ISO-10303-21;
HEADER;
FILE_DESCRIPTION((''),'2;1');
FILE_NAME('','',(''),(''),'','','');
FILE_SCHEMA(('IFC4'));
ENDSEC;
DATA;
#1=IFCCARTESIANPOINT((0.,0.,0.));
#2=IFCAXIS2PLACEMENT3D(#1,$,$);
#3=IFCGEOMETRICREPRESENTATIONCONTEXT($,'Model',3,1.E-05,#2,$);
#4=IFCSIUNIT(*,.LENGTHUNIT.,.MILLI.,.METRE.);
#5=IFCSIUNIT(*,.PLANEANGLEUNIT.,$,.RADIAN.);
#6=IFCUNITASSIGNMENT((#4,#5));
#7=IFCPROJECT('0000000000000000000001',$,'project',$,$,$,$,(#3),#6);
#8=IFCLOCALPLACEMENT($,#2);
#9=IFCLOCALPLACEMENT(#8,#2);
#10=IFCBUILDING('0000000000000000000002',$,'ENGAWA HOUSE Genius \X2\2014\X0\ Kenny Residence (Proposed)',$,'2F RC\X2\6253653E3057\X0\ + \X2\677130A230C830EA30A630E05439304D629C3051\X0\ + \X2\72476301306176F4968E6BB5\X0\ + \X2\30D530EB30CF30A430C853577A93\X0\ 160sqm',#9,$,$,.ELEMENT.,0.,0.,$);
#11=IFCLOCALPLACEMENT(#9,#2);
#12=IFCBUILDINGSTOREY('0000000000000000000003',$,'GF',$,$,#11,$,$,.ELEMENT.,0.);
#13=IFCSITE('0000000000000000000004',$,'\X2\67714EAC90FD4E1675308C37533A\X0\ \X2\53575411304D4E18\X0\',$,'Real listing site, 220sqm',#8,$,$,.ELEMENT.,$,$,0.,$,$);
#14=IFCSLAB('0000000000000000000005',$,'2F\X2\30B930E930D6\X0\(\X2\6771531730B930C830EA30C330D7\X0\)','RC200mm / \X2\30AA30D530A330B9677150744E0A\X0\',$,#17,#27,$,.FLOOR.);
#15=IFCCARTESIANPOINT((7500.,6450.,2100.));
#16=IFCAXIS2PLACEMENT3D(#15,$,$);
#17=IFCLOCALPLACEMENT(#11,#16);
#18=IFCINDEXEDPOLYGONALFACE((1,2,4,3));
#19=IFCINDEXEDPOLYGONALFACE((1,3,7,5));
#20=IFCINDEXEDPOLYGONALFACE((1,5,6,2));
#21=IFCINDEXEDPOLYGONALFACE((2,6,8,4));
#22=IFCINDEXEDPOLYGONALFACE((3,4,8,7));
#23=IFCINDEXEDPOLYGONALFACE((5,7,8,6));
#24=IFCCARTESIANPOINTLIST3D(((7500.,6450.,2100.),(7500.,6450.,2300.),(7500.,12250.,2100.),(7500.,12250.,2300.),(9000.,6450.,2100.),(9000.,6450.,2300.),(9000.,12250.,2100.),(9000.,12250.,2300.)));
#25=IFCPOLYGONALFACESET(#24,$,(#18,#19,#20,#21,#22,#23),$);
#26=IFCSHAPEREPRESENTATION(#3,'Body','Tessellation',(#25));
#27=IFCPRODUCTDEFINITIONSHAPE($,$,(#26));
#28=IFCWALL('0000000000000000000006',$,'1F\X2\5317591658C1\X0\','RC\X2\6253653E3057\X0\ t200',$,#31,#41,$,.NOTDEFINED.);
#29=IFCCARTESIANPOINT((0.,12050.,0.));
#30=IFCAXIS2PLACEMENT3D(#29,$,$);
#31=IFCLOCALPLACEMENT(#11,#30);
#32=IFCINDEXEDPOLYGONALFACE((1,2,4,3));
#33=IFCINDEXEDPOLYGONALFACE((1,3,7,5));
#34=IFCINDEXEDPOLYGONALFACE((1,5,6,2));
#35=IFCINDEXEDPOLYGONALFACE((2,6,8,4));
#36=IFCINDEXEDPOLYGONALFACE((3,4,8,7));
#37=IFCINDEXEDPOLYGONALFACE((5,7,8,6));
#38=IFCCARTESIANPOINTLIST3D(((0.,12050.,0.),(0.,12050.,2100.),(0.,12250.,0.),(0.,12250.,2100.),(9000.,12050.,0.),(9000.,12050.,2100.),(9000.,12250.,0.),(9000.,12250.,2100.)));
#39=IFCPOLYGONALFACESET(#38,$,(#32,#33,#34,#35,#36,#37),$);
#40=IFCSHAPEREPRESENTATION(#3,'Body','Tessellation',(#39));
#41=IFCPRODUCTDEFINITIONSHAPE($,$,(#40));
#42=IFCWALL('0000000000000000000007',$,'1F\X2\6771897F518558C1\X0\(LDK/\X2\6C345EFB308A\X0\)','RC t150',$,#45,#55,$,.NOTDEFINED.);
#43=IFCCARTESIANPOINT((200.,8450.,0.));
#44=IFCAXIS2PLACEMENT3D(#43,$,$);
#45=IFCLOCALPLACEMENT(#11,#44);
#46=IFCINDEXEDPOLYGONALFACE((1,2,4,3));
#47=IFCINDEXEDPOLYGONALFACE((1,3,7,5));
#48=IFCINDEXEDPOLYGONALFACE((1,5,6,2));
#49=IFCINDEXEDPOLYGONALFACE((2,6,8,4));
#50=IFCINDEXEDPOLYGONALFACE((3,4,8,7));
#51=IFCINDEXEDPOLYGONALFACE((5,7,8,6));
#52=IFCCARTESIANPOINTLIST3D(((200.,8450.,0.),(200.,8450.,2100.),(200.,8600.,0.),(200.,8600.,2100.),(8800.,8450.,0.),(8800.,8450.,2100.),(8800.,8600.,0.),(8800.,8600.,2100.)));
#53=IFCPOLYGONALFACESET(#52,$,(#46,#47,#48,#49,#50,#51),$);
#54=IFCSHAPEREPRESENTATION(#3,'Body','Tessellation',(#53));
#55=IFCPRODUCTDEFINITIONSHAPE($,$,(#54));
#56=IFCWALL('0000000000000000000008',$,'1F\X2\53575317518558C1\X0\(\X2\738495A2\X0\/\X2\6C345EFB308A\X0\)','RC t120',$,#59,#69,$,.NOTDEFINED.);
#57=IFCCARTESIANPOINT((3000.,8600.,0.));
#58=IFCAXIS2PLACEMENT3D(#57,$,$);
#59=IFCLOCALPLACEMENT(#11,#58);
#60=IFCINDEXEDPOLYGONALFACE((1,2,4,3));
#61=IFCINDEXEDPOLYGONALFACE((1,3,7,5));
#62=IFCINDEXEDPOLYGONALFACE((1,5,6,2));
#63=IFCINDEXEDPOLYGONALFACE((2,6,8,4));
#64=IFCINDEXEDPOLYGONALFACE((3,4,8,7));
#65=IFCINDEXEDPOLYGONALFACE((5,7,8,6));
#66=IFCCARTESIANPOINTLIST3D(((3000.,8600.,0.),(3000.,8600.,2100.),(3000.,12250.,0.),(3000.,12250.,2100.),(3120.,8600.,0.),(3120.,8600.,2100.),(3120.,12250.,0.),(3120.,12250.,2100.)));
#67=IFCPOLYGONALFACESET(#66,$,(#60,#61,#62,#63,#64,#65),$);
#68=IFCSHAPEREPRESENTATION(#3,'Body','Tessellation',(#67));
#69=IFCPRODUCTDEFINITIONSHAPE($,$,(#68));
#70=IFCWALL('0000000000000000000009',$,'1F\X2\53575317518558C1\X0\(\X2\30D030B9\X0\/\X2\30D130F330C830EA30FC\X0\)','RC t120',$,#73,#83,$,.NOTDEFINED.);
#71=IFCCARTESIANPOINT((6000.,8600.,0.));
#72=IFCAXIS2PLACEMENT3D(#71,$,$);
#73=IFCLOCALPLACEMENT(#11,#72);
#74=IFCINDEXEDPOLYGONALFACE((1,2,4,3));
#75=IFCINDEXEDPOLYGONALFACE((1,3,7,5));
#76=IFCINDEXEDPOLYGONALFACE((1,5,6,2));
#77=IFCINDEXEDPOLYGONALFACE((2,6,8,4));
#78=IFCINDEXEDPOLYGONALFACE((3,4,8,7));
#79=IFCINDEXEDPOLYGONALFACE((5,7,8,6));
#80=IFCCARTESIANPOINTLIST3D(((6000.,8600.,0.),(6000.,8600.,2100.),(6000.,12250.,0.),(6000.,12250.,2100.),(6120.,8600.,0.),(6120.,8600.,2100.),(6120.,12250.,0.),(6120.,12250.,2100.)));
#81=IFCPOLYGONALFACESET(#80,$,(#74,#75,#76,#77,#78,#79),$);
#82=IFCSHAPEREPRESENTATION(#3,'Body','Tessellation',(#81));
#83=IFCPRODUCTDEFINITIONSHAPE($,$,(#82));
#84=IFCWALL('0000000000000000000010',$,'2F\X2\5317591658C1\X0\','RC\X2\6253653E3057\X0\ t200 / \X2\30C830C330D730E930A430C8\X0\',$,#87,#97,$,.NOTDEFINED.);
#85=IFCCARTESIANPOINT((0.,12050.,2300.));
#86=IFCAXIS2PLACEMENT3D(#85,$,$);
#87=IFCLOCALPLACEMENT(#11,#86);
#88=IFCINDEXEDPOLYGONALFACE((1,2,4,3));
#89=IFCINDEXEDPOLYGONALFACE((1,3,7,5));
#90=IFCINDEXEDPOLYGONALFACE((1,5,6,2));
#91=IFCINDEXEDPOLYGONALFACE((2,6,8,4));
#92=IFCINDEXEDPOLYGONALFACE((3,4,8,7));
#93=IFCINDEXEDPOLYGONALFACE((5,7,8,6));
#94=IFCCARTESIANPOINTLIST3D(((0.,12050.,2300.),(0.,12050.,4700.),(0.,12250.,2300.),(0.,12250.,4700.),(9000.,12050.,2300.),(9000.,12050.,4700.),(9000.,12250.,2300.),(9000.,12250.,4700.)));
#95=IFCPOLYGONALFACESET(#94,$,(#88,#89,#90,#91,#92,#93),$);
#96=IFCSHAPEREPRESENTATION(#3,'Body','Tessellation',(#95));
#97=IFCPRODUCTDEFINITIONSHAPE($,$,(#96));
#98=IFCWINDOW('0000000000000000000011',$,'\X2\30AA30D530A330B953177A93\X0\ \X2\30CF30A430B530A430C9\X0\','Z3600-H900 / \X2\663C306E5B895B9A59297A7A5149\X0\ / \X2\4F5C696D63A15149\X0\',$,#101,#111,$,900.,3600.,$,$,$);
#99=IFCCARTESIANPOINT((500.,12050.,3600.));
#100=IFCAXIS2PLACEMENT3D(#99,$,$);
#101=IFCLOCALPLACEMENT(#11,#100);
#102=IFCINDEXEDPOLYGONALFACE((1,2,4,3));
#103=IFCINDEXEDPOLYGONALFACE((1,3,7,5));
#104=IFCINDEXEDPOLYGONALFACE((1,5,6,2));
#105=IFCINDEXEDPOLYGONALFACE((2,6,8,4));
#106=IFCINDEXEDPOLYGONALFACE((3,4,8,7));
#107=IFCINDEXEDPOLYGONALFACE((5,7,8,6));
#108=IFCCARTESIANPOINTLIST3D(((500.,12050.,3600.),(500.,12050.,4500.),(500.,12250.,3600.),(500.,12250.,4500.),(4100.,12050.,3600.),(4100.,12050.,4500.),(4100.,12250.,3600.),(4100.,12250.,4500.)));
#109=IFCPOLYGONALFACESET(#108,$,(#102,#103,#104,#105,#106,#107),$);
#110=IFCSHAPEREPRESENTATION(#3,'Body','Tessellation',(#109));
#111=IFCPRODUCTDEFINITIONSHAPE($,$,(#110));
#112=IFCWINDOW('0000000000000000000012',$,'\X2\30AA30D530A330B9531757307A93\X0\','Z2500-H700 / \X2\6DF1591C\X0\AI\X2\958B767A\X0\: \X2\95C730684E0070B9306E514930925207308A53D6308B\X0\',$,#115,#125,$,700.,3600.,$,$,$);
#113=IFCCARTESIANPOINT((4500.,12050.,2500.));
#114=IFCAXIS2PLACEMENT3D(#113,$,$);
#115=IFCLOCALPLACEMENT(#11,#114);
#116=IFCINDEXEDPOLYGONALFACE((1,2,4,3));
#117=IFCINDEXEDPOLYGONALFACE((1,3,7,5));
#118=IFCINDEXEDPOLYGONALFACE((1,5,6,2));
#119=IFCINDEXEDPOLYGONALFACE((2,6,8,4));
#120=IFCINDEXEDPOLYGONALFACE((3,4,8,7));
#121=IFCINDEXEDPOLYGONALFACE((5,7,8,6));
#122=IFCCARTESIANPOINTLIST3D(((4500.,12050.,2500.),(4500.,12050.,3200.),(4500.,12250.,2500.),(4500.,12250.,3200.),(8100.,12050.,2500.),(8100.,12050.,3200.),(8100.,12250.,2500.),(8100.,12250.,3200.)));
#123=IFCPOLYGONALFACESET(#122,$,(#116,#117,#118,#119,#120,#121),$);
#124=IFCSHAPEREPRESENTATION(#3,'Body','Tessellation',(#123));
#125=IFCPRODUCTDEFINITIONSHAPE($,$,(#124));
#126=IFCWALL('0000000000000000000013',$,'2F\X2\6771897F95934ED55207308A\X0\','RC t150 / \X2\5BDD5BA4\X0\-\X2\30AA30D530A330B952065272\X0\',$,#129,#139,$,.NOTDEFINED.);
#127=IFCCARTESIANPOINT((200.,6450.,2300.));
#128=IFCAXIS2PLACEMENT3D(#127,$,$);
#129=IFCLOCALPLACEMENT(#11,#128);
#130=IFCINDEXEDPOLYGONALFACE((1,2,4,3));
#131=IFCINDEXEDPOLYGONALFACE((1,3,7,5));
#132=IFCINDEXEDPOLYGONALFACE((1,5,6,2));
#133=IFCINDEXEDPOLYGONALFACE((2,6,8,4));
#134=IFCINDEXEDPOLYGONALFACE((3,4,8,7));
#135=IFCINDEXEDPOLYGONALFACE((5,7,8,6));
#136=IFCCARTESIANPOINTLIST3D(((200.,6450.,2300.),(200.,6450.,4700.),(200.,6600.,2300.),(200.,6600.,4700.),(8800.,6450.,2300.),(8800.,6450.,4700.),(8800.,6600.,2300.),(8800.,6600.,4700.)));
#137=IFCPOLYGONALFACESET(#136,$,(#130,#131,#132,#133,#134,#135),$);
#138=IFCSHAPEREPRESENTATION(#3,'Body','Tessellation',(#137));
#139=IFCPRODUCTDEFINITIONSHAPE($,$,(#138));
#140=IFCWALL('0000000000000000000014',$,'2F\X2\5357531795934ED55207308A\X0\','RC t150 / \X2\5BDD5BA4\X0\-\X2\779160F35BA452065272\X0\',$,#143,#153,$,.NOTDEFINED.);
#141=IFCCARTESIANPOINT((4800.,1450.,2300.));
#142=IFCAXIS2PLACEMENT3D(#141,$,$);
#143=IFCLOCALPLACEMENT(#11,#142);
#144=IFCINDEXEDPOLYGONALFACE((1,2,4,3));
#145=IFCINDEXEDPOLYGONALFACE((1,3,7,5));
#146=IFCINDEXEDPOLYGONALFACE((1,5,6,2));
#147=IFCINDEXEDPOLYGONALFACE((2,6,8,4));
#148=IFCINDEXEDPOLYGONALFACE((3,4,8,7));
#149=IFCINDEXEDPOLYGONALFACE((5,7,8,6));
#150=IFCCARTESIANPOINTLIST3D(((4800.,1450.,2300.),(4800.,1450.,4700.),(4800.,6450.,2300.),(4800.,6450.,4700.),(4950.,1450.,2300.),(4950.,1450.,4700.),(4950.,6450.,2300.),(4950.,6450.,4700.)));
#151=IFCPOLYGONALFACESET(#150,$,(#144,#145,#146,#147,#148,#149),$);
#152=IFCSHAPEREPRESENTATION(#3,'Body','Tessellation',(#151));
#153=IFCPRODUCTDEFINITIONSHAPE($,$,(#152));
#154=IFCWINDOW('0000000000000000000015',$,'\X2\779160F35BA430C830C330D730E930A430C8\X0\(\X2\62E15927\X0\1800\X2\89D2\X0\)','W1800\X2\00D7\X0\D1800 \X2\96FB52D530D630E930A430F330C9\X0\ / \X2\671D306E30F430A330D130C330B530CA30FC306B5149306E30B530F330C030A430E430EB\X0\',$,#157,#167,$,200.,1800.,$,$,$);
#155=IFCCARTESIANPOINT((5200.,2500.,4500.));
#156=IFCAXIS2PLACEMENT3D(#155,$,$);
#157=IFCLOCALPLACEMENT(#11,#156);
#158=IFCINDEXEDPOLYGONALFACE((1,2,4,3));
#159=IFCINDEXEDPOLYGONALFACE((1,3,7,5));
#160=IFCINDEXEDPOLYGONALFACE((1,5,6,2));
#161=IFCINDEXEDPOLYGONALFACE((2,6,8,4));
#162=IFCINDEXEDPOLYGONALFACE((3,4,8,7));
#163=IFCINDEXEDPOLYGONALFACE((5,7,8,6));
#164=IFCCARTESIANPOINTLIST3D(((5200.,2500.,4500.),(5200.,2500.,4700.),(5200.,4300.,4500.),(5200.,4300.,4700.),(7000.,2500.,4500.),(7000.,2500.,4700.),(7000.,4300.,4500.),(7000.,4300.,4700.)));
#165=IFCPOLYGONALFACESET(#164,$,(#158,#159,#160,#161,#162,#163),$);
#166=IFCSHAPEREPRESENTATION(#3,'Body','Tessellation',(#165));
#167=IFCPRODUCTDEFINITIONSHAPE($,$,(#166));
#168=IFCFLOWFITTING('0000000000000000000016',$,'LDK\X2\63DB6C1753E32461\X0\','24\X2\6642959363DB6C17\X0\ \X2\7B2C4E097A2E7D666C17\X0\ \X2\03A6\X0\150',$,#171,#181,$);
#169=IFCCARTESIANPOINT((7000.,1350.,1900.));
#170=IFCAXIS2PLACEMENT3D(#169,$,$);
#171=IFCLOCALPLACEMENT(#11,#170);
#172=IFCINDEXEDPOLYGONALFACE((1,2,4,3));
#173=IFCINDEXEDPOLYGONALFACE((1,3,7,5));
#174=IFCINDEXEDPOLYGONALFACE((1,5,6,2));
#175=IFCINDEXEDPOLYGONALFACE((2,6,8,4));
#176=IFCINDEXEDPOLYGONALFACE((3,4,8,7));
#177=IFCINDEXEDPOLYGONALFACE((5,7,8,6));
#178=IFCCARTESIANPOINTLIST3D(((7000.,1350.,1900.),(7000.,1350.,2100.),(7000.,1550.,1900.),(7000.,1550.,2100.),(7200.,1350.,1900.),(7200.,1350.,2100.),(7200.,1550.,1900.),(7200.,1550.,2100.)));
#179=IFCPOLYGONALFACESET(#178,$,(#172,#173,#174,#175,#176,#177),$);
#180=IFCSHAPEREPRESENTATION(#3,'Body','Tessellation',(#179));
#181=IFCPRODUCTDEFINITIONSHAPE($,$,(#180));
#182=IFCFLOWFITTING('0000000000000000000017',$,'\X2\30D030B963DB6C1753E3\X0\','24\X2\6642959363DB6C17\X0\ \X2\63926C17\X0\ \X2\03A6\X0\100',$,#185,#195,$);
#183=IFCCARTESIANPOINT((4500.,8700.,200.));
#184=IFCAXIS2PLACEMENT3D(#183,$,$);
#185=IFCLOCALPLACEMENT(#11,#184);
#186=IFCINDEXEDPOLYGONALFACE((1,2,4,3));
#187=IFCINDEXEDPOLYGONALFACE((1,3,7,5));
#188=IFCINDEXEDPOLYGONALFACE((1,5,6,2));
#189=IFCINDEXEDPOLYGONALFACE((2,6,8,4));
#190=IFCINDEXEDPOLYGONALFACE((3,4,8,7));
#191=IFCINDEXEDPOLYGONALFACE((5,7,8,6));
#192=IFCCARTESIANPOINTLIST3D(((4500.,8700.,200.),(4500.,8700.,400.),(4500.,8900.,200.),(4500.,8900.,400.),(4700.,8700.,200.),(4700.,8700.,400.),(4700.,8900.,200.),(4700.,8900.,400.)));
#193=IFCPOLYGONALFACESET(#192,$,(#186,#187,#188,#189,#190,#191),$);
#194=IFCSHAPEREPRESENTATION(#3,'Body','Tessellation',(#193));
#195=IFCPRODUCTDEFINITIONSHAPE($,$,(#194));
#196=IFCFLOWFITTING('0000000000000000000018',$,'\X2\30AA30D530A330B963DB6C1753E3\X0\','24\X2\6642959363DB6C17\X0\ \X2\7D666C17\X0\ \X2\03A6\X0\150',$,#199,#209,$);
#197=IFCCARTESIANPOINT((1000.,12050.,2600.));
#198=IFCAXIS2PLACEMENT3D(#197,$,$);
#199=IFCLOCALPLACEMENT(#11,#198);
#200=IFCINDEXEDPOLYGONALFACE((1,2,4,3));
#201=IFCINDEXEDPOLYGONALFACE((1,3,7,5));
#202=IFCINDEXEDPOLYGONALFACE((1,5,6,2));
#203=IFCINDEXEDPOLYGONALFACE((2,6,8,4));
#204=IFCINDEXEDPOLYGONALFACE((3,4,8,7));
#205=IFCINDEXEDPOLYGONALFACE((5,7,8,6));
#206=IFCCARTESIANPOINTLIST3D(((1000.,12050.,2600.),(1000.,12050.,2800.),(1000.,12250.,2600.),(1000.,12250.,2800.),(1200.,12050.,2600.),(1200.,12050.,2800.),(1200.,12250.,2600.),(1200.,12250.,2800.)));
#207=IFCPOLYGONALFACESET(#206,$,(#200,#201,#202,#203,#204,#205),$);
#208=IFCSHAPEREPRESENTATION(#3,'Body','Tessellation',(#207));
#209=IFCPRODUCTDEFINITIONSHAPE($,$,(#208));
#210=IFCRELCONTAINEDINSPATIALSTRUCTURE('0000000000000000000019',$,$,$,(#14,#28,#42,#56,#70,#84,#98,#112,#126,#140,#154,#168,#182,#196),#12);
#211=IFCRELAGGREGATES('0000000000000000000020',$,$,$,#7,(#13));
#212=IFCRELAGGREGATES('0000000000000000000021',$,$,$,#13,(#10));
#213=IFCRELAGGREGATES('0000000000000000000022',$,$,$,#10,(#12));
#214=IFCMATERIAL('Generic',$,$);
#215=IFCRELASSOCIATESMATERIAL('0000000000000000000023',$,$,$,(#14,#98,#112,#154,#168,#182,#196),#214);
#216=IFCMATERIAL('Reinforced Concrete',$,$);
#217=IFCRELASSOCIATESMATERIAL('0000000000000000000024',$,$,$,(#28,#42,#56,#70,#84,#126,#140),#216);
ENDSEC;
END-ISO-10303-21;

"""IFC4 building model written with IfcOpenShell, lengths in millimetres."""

from ifc_helpers import new_model, si_unit, frame, frame_2d, origin, place, context, project, spatial, rectangle, extrude, material, element, fill, save


model = new_model("IFC4")

# Units and contexts
model_context = context("Model", 3, precision=1e-05, world=origin())
ifc_project = project(units=[si_unit("LENGTHUNIT", "METRE", prefix="MILLI"), si_unit("PLANEANGLEUNIT", "RADIAN")], contexts=[model_context])

# Site, building, storey
site_placement = place(None, origin())
site = spatial("IfcSite", under=ifc_project, at=site_placement, Name="東京都世田谷区 南向き丘", ObjectType="Real listing site, 220sqm", CompositionType="ELEMENT", RefElevation=0.0)
building_placement = place(site_placement, origin())
building = spatial("IfcBuilding", under=site, at=building_placement, Name="ENGAWA HOUSE Genius — Kenny Residence (Proposed)", ObjectType="2F RC打放し + 東アトリウム吹き抜け + 片持ち直階段 + フルハイト南窓 160sqm", CompositionType="ELEMENT", ElevationOfRefHeight=0.0, ElevationOfTerrain=0.0)
storey_placement = place(building_placement, origin())
storey = spatial("IfcBuildingStorey", under=building, at=storey_placement, Name="GF", CompositionType="ELEMENT", Elevation=0.0)

# Slab
ifc_material_1 = material(Name="Generic")
slab_placement = place(storey_placement, frame((7500.0, 6450.0, 2100.0)))
element("IfcSlab", 1, at=slab_placement, inside=storey, material=ifc_material_1, Name="2Fスラブ(東北ストリップ)", Description="RC200mm / オフィス東側上", PredefinedType="FLOOR", context=model_context, shape_type="SweptSolid", body=[
    extrude(rectangle(XDim=1500.0, YDim=5800.0, at=frame_2d((750.0, 2900.0))), frame((7500.0, 6450.0, 2100.0)), (0.0, 0.0, 1.0), 200.0),
])

# Walls
ifc_material_2 = material(Name="Reinforced Concrete")
wall_1_placement = place(storey_placement, frame((0.0, 12050.0, 0.0)))
element("IfcWall", 2, at=wall_1_placement, inside=storey, material=ifc_material_2, Name="1F北外壁", Description="RC打放し t200", PredefinedType="NOTDEFINED", context=model_context, shape_type="SweptSolid", body=[
    extrude(rectangle(XDim=9000.0, YDim=200.0, at=frame_2d((4500.0, 100.0))), frame((0.0, 12050.0, 0.0)), (0.0, 0.0, 1.0), 2100.0),
])
wall_2_placement = place(storey_placement, frame((200.0, 8450.0, 0.0)))
element("IfcWall", 3, at=wall_2_placement, inside=storey, material=ifc_material_2, Name="1F東西内壁(LDK/水廻り)", Description="RC t150", PredefinedType="NOTDEFINED", context=model_context, shape_type="SweptSolid", body=[
    extrude(rectangle(XDim=8600.0, YDim=150.0, at=frame_2d((4300.0, 75.0))), frame((200.0, 8450.0, 0.0)), (0.0, 0.0, 1.0), 2100.0),
])
wall_3_placement = place(storey_placement, frame((3000.0, 8600.0, 0.0)))
element("IfcWall", 4, at=wall_3_placement, inside=storey, material=ifc_material_2, Name="1F南北内壁(玄関/水廻り)", Description="RC t120", PredefinedType="NOTDEFINED", context=model_context, shape_type="SweptSolid", body=[
    extrude(rectangle(XDim=120.0, YDim=3650.0, at=frame_2d((60.0, 1825.0))), frame((3000.0, 8600.0, 0.0)), (0.0, 0.0, 1.0), 2100.0),
])
wall_4_placement = place(storey_placement, frame((6000.0, 8600.0, 0.0)))
element("IfcWall", 5, at=wall_4_placement, inside=storey, material=ifc_material_2, Name="1F南北内壁(バス/パントリー)", Description="RC t120", PredefinedType="NOTDEFINED", context=model_context, shape_type="SweptSolid", body=[
    extrude(rectangle(XDim=120.0, YDim=3650.0, at=frame_2d((60.0, 1825.0))), frame((6000.0, 8600.0, 0.0)), (0.0, 0.0, 1.0), 2100.0),
])

# Wall, openings, windows
wall_5_placement = place(storey_placement, frame((0.0, 12050.0, 2300.0)))
wall_5 = element("IfcWall", 6, at=wall_5_placement, inside=storey, material=ifc_material_2, Name="2F北外壁", Description="RC打放し t200 / トップライト", PredefinedType="NOTDEFINED", context=model_context, shape_type="SweptSolid", body=[
    extrude(rectangle(XDim=9000.0, YDim=200.0, at=frame_2d((4500.0, 100.0))), frame((0.0, 12050.0, 2300.0)), (0.0, 0.0, 1.0), 2400.0),
])
opening_1_placement = place(storey_placement, frame((500.0, 12050.0, 3600.0)))
opening_1 = element("IfcOpeningElement", 7, at=opening_1_placement, cuts=wall_5, PredefinedType="NOTDEFINED", context=model_context, shape_type="SweptSolid", body=[
    extrude(rectangle(XDim=3600.0, YDim=200.0, at=frame_2d((1800.0, 100.0))), frame((500.0, 12050.0, 3600.0)), (0.0, 0.0, 1.0), 900.0),
])
opening_2_placement = place(storey_placement, frame((4500.0, 12050.0, 2500.0)))
opening_2 = element("IfcOpeningElement", 8, at=opening_2_placement, cuts=wall_5, PredefinedType="NOTDEFINED", context=model_context, shape_type="SweptSolid", body=[
    extrude(rectangle(XDim=3600.0, YDim=200.0, at=frame_2d((1800.0, 100.0))), frame((4500.0, 12050.0, 2500.0)), (0.0, 0.0, 1.0), 700.0),
])
window_1_placement = place(storey_placement, frame((500.0, 12050.0, 3600.0)))
window_1 = element("IfcWindow", 9, at=window_1_placement, inside=storey, material=ifc_material_1, Name="オフィス北窓 ハイサイド", Description="Z3600-H900 / 昼の安定天空光 / 作業採光", OverallHeight=900.0, OverallWidth=3600.0, context=model_context, shape_type="SweptSolid", body=[
    extrude(rectangle(XDim=3600.0, YDim=200.0, at=frame_2d((1800.0, 100.0))), frame((500.0, 12050.0, 3600.0)), (0.0, 0.0, 1.0), 900.0),
])
fill(opening_1, window_1)
window_2_placement = place(storey_placement, frame((4500.0, 12050.0, 2500.0)))
window_2 = element("IfcWindow", 10, at=window_2_placement, inside=storey, material=ifc_material_1, Name="オフィス北地窓", Description="Z2500-H700 / 深夜AI開発: 闇と一点の光を切り取る", OverallHeight=700.0, OverallWidth=3600.0, context=model_context, shape_type="SweptSolid", body=[
    extrude(rectangle(XDim=3600.0, YDim=200.0, at=frame_2d((1800.0, 100.0))), frame((4500.0, 12050.0, 2500.0)), (0.0, 0.0, 1.0), 700.0),
])
fill(opening_2, window_2)

# Walls
wall_6_placement = place(storey_placement, frame((200.0, 6450.0, 2300.0)))
element("IfcWall", 11, at=wall_6_placement, inside=storey, material=ifc_material_2, Name="2F東西間仕切り", Description="RC t150 / 寝室-オフィス分割", PredefinedType="NOTDEFINED", context=model_context, shape_type="SweptSolid", body=[
    extrude(rectangle(XDim=8600.0, YDim=150.0, at=frame_2d((4300.0, 75.0))), frame((200.0, 6450.0, 2300.0)), (0.0, 0.0, 1.0), 2400.0),
])
wall_7_placement = place(storey_placement, frame((4800.0, 1450.0, 2300.0)))
element("IfcWall", 12, at=wall_7_placement, inside=storey, material=ifc_material_2, Name="2F南北間仕切り", Description="RC t150 / 寝室-瞑想室分割", PredefinedType="NOTDEFINED", context=model_context, shape_type="SweptSolid", body=[
    extrude(rectangle(XDim=150.0, YDim=5000.0, at=frame_2d((75.0, 2500.0))), frame((4800.0, 1450.0, 2300.0)), (0.0, 0.0, 1.0), 2400.0),
])

# Window
window_3_placement = place(storey_placement, frame((5200.0, 2500.0, 4500.0)))
element("IfcWindow", 13, at=window_3_placement, inside=storey, material=ifc_material_1, Name="瞑想室トップライト(拡大1800角)", Description="W1800×D1800 電動ブラインド / 朝のヴィパッサナーに光のサンダイヤル", OverallHeight=200.0, OverallWidth=1800.0, context=model_context, shape_type="SweptSolid", body=[
    extrude(rectangle(XDim=1800.0, YDim=1800.0, at=frame_2d((900.0, 900.0))), frame((5200.0, 2500.0, 4500.0)), (0.0, 0.0, 1.0), 200.0),
])

# Flow fittings
flow_fitting_1_placement = place(storey_placement, frame((7000.0, 1350.0, 1900.0)))
element("IfcFlowFitting", 14, at=flow_fitting_1_placement, inside=storey, material=ifc_material_1, Name="LDK換気口②", Description="24時間換気 第三種給気 Φ150", context=model_context, shape_type="SweptSolid", body=[
    extrude(rectangle(XDim=200.0, YDim=200.0, at=frame_2d((100.0, 100.0))), frame((7000.0, 1350.0, 1900.0)), (0.0, 0.0, 1.0), 200.0),
])
flow_fitting_2_placement = place(storey_placement, frame((4500.0, 8700.0, 200.0)))
element("IfcFlowFitting", 15, at=flow_fitting_2_placement, inside=storey, material=ifc_material_1, Name="バス換気口", Description="24時間換気 排気 Φ100", context=model_context, shape_type="SweptSolid", body=[
    extrude(rectangle(XDim=200.0, YDim=200.0, at=frame_2d((100.0, 100.0))), frame((4500.0, 8700.0, 200.0)), (0.0, 0.0, 1.0), 200.0),
])
flow_fitting_3_placement = place(storey_placement, frame((1000.0, 12050.0, 2600.0)))
element("IfcFlowFitting", 16, at=flow_fitting_3_placement, inside=storey, material=ifc_material_1, Name="オフィス換気口", Description="24時間換気 給気 Φ150", context=model_context, shape_type="SweptSolid", body=[
    extrude(rectangle(XDim=200.0, YDim=200.0, at=frame_2d((100.0, 100.0))), frame((1000.0, 12050.0, 2600.0)), (0.0, 0.0, 1.0), 200.0),
])

save(model, "model.ifc")
